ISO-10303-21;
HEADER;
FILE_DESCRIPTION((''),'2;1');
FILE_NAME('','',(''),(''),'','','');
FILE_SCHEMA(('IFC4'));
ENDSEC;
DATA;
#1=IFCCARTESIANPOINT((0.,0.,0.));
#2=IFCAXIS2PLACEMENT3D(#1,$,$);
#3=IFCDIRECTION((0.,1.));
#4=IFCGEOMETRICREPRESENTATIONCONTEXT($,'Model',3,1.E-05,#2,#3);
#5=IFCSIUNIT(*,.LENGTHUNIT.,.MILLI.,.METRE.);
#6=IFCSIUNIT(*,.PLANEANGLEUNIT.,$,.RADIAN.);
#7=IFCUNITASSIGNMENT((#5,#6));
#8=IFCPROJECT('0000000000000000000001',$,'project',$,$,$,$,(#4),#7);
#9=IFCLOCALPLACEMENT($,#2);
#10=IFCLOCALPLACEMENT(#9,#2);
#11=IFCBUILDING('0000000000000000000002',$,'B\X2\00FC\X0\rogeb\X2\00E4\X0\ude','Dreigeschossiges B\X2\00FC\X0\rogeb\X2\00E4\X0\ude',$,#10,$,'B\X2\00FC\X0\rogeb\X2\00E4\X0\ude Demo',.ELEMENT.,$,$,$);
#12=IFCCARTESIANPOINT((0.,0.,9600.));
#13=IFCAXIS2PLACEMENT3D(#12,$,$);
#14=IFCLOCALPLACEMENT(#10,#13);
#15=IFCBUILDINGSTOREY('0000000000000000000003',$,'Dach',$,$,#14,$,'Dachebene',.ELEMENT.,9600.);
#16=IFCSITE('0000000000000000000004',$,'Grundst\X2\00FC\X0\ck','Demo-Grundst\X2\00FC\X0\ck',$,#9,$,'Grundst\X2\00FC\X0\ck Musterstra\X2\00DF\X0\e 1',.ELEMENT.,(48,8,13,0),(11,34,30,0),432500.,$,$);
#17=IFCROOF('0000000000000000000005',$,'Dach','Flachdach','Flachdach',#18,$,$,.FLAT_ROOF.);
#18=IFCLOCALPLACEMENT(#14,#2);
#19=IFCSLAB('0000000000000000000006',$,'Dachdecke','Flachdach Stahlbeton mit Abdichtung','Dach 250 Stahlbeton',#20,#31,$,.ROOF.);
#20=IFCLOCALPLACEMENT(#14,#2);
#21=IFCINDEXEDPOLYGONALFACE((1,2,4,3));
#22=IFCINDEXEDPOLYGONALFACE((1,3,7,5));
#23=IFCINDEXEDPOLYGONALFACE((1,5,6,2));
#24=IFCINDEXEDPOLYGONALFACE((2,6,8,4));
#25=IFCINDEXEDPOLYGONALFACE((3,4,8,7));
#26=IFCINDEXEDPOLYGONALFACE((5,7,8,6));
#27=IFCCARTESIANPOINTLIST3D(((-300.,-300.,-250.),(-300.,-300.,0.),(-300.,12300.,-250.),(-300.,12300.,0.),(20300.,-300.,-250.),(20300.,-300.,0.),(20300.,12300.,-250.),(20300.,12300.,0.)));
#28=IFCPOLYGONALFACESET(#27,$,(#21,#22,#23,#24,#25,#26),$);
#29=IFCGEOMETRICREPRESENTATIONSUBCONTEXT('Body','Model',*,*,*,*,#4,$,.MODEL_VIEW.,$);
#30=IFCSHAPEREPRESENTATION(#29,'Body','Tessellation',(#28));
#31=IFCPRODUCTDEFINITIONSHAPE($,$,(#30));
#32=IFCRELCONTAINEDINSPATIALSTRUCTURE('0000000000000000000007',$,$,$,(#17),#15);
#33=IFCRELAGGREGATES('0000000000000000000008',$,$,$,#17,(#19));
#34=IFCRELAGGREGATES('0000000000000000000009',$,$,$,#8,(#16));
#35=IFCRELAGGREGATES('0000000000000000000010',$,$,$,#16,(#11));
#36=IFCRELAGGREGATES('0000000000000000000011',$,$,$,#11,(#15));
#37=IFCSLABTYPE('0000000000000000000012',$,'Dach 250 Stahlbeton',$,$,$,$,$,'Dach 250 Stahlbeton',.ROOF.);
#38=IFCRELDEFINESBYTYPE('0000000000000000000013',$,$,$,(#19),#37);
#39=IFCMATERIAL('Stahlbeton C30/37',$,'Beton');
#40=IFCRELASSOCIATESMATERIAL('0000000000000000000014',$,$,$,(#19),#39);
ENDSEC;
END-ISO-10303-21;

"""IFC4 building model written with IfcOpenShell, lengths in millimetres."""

from ifc_helpers import new_model, si_unit, direction, frame, frame_2d, origin, place, context, subcontext, project, spatial, rectangle, extrude, material, type_object, element, aggregate, save


model = new_model("IFC4")

# Units and contexts
model_context = context("Model", 3, precision=1e-05, world=origin(), true_north=direction((0.0, 1.0)))
body_context = subcontext(model_context, "Body", "Model", "MODEL_VIEW")
ifc_project = project(units=[si_unit("LENGTHUNIT", "METRE", prefix="MILLI"), si_unit("PLANEANGLEUNIT", "RADIAN")], contexts=[model_context])

# Site, building, storey
site_placement = place(None, origin())
site = spatial("IfcSite", under=ifc_project, at=site_placement, Name="Grundstück", Description="Demo-Grundstück", LongName="Grundstück Musterstraße 1", CompositionType="ELEMENT", RefLatitude=(48, 8, 13, 0), RefLongitude=(11, 34, 30, 0), RefElevation=432500.0)
building_placement = place(site_placement, origin())
building = spatial("IfcBuilding", under=site, at=building_placement, Name="Bürogebäude", Description="Dreigeschossiges Bürogebäude", LongName="Bürogebäude Demo", CompositionType="ELEMENT")
storey_placement = place(building_placement, frame((0.0, 0.0, 9600.0)))
storey = spatial("IfcBuildingStorey", under=building, at=storey_placement, Name="Dach", LongName="Dachebene", CompositionType="ELEMENT", Elevation=9600.0)

# Roof, slab
roof_placement = place(storey_placement, origin())
roof = element("IfcRoof", 1, at=roof_placement, inside=storey, Name="Dach", Description="Flachdach", ObjectType="Flachdach", PredefinedType="FLAT_ROOF")
ifc_material = material(Name="Stahlbeton C30/37", Category="Beton")
slab_type = type_object("IfcSlabType", Name="Dach 250 Stahlbeton", ElementType="Dach 250 Stahlbeton", PredefinedType="ROOF")
slab_placement = place(roof_placement, origin())
slab = element("IfcSlab", 2, at=slab_placement, type_object=slab_type, material=ifc_material, Name="Dachdecke", Description="Flachdach Stahlbeton mit Abdichtung", ObjectType="Dach 250 Stahlbeton", PredefinedType="ROOF", context=body_context, shape_type="SweptSolid", body=[
    extrude(rectangle(XDim=20600.0, YDim=12600.0, at=frame_2d((10000.0, 6000.0))), frame((0.0, 0.0, -250.0)), (0.0, 0.0, 1.0), 250.0),
])
aggregate(roof, [slab])

save(model, "model.ifc")
